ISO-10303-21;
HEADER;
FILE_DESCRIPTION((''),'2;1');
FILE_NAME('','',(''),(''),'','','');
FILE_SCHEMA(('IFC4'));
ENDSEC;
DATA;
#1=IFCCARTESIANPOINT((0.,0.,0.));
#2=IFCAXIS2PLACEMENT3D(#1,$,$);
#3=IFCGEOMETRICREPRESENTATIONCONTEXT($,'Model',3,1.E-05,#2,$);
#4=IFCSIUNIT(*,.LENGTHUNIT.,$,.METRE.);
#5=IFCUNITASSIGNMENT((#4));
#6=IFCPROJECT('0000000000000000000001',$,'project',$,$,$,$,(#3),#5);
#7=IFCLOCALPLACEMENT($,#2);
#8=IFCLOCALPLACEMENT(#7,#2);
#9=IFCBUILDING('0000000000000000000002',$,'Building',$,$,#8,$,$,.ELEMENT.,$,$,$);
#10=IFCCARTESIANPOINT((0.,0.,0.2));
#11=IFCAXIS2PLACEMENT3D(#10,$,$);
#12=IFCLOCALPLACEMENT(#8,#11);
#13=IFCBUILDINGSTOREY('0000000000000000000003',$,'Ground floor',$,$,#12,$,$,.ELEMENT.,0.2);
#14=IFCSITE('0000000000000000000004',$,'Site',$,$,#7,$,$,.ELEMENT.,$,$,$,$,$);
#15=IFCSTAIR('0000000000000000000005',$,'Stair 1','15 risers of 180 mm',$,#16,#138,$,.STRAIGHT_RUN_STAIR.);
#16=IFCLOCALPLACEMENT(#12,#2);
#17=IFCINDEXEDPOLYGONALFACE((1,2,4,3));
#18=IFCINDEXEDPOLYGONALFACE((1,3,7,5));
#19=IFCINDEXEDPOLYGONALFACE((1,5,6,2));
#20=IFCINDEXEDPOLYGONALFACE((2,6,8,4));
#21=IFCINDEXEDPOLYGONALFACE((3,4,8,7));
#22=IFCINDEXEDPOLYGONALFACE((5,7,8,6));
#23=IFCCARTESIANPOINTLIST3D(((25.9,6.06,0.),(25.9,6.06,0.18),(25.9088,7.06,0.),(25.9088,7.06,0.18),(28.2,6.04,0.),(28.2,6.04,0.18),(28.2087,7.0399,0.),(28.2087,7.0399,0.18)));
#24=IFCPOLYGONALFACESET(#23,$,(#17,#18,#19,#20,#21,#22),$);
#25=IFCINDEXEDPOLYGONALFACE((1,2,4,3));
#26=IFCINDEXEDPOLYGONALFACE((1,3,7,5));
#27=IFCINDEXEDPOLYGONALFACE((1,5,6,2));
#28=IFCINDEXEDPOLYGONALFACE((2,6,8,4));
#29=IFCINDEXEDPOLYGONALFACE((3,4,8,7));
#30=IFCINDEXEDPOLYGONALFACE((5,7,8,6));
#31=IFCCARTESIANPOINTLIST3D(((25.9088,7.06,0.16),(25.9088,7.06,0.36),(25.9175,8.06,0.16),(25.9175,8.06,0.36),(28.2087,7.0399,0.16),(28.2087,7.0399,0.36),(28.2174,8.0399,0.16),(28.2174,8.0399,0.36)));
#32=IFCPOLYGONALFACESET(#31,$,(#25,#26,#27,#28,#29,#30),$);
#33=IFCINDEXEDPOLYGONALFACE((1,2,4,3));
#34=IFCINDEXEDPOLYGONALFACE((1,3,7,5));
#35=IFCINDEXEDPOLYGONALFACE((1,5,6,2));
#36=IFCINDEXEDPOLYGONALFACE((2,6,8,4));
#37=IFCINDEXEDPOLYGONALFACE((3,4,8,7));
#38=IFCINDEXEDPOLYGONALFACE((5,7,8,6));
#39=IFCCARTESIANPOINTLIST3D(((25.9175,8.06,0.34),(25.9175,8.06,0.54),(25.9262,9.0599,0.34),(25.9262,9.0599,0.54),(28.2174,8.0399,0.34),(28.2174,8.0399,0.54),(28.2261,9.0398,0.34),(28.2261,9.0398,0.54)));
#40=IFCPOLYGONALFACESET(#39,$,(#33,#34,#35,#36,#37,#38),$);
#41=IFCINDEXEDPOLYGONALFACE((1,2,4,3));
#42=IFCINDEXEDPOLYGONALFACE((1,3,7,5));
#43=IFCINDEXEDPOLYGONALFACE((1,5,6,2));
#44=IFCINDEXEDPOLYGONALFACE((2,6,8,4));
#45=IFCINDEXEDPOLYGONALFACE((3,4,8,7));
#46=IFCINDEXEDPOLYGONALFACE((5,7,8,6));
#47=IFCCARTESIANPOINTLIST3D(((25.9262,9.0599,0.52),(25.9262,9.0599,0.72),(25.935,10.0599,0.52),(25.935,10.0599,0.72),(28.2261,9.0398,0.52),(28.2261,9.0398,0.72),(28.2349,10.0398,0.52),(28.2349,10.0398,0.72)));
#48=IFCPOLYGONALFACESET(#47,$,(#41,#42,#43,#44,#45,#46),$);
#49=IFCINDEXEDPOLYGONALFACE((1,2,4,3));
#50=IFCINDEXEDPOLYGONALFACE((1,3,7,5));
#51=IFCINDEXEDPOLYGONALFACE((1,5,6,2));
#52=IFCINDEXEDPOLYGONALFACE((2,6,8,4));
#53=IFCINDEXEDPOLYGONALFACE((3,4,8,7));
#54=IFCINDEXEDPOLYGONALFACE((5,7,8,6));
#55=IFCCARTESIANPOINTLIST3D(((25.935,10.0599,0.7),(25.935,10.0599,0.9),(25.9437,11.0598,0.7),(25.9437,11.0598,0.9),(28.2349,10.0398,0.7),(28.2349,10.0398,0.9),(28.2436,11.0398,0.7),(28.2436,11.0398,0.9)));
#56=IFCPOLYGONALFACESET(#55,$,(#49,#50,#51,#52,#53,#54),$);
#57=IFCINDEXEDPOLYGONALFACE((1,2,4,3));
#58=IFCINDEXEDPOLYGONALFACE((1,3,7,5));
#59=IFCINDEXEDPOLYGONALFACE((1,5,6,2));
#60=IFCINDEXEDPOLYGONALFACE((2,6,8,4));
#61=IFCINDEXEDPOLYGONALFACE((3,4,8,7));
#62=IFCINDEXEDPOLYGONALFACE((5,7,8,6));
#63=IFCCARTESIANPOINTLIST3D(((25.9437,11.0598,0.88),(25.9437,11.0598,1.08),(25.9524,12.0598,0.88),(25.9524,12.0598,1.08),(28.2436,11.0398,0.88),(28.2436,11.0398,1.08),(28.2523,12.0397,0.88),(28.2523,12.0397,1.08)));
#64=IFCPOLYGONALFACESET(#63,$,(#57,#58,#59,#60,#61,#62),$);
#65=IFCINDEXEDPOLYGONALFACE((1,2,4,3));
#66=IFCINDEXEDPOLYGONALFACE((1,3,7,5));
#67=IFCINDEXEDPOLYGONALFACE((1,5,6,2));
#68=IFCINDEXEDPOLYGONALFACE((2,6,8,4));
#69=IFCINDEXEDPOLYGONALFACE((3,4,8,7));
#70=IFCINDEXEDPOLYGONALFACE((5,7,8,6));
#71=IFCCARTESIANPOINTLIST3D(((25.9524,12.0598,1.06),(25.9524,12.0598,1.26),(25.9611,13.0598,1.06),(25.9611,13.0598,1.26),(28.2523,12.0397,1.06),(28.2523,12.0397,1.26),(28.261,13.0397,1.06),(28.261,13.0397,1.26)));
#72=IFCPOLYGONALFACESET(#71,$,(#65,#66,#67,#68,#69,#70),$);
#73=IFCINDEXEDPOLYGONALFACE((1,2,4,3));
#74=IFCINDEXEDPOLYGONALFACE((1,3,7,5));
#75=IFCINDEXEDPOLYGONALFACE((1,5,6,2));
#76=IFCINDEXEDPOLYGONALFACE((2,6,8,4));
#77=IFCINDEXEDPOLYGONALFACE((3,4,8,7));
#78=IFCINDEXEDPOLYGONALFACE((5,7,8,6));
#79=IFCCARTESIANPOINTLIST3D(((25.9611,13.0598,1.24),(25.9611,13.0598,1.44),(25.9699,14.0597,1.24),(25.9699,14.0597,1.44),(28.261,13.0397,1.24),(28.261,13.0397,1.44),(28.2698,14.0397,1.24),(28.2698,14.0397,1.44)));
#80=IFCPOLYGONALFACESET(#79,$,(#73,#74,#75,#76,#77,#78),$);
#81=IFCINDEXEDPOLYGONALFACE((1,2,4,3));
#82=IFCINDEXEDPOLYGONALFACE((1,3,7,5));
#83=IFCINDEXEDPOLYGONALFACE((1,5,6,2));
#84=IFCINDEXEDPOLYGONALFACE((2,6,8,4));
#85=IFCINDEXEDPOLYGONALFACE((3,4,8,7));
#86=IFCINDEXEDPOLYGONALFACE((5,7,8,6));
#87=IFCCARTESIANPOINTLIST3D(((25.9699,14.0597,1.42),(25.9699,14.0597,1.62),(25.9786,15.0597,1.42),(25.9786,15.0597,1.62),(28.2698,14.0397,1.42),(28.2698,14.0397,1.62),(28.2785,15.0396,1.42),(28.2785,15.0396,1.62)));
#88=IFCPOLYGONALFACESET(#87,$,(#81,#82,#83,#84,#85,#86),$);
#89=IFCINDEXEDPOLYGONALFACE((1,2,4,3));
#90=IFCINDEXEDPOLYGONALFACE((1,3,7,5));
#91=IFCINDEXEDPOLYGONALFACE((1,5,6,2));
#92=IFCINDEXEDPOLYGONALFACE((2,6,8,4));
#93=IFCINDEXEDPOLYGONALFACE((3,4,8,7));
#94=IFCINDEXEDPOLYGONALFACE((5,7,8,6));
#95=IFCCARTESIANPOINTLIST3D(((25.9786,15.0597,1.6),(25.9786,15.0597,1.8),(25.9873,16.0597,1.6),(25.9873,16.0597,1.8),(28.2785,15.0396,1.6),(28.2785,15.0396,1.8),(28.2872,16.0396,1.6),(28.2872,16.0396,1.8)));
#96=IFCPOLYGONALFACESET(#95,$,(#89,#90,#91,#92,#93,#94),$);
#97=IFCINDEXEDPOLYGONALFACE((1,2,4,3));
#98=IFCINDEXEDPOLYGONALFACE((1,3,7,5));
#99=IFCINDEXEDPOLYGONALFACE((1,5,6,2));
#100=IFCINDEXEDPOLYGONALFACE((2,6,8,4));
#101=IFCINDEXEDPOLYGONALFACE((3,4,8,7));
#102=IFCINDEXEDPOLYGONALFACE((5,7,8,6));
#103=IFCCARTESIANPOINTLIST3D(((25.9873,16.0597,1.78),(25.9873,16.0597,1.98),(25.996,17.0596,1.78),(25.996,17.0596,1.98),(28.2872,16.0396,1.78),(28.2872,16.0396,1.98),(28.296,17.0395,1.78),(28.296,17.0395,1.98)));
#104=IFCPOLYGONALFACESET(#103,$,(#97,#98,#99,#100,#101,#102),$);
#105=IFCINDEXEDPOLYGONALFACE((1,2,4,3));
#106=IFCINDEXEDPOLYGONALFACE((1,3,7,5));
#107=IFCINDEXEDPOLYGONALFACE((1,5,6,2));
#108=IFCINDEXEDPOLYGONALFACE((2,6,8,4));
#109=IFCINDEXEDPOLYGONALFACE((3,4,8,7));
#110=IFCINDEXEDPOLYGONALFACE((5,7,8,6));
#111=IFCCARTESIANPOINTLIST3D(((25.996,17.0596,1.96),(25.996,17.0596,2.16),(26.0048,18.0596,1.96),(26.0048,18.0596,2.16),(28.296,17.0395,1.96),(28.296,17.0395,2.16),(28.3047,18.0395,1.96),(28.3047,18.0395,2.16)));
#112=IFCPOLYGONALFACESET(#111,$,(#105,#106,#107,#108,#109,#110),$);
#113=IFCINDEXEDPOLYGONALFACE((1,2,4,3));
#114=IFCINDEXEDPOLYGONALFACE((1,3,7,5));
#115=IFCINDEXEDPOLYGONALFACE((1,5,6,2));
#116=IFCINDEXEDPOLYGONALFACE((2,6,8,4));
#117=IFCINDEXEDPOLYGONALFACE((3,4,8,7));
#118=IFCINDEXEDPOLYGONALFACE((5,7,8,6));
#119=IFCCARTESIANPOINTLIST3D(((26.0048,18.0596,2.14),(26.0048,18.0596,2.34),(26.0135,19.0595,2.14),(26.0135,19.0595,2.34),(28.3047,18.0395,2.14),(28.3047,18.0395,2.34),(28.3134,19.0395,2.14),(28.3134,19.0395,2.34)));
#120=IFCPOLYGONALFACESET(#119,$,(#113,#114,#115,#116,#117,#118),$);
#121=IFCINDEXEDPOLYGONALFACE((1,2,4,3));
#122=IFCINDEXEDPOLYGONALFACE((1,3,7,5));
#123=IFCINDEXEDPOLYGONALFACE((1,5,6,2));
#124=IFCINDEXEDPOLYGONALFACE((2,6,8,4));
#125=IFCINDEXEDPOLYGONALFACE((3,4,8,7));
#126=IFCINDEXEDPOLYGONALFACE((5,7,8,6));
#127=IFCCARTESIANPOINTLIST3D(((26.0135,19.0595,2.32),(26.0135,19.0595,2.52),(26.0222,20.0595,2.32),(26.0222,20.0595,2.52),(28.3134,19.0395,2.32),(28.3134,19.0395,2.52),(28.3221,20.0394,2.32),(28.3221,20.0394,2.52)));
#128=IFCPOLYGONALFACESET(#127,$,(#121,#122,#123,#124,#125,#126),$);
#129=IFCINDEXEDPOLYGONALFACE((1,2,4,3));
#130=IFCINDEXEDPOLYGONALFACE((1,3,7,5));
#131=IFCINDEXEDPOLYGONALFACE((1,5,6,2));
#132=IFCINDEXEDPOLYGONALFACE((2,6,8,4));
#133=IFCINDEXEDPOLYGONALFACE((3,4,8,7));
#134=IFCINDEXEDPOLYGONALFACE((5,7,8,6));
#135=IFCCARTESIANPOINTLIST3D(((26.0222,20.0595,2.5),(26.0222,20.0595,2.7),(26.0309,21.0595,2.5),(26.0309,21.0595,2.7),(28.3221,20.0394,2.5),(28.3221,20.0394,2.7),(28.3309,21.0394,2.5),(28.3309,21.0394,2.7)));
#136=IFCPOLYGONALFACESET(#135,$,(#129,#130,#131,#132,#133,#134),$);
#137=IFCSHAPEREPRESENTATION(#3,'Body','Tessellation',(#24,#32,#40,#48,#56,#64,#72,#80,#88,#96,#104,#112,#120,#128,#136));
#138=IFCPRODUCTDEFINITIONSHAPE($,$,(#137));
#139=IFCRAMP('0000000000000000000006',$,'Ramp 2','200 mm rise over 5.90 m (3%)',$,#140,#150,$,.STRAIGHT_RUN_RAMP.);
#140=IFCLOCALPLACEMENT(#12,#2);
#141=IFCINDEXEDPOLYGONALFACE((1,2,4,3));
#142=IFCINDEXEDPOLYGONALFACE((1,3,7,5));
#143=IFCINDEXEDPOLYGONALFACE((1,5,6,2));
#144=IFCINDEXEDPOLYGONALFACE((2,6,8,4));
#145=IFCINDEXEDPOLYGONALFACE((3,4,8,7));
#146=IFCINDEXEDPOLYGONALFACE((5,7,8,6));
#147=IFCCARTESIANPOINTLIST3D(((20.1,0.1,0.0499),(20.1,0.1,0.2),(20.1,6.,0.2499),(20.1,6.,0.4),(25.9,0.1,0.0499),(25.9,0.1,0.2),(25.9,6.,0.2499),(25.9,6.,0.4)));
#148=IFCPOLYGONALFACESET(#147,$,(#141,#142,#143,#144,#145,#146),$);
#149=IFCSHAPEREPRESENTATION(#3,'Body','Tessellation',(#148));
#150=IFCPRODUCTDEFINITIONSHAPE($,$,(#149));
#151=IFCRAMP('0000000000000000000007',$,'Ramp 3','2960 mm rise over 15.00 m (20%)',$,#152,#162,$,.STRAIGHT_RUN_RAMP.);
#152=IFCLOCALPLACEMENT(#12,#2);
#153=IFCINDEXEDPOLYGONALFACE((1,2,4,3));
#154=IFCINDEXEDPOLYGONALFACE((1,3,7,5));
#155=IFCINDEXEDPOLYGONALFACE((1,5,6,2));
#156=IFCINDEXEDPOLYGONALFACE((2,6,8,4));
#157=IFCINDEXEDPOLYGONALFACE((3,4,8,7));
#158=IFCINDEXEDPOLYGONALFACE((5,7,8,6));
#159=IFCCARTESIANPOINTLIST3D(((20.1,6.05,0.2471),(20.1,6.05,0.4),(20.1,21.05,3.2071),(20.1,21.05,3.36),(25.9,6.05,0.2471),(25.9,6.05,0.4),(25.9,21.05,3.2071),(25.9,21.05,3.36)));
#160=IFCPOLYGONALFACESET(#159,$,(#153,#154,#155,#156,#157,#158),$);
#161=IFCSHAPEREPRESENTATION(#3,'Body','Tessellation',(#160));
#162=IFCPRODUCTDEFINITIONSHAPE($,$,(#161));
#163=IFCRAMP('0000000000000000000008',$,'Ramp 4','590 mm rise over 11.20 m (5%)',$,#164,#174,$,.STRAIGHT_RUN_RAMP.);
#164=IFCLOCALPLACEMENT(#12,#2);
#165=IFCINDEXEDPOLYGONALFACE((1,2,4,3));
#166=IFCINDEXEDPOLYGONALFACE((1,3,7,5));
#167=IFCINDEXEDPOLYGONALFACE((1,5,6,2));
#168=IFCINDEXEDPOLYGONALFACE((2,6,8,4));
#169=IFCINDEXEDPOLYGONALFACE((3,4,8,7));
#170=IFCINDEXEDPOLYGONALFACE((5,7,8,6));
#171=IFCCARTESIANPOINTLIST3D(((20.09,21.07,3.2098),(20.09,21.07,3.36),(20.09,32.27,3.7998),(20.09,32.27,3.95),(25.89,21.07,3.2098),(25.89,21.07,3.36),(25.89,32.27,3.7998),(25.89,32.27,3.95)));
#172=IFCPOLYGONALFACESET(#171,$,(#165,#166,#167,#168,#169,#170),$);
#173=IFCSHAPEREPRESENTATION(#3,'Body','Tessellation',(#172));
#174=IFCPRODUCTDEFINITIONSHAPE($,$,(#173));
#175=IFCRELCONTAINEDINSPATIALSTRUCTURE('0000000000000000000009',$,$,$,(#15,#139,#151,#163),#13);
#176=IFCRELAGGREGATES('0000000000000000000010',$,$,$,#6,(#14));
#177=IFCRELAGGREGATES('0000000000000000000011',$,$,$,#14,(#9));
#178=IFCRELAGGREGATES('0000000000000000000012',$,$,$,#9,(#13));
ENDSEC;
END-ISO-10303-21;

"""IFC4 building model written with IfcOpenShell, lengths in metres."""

from ifc_helpers import new_model, si_unit, frame, origin, place, context, project, spatial, polyline, outline, extrude, element, save


model = new_model("IFC4")

# Units and contexts
model_context = context("Model", 3, precision=1e-05, world=origin())
ifc_project = project(units=[si_unit("LENGTHUNIT", "METRE")], contexts=[model_context])

# Site, building, storey
site_placement = place(None, origin())
site = spatial("IfcSite", under=ifc_project, at=site_placement, Name="Site", CompositionType="ELEMENT")
building_placement = place(site_placement, origin())
building = spatial("IfcBuilding", under=site, at=building_placement, Name="Building", CompositionType="ELEMENT")
storey_placement = place(building_placement, frame((0.0, 0.0, 0.2)))
storey = spatial("IfcBuildingStorey", under=building, at=storey_placement, Name="Ground floor", CompositionType="ELEMENT", Elevation=0.2)

# Stair
stair_placement = place(storey_placement, frame((27.05, 6.05, 0.0), z_axis=(0.0, 0.0, 1.0), x_axis=(0.008727, 0.999962, 0.0)))
element("IfcStair", 1, at=stair_placement, inside=storey, Name="Stair 1", Description="15 risers of 180 mm", PredefinedType="STRAIGHT_RUN_STAIR", context=model_context, shape_type="SweptSolid", body=[
    extrude(outline(polyline([(0.0, -1.15), (1.0, -1.15), (1.0, 1.15), (0.0, 1.15), (0.0, -1.15)])), origin(), (0.0, 0.0, 1.0), 0.18),
    extrude(outline(polyline([(1.0, -1.15), (2.0, -1.15), (2.0, 1.15), (1.0, 1.15), (1.0, -1.15)])), frame((0.0, 0.0, 0.16)), (0.0, 0.0, 1.0), 0.2),
    extrude(outline(polyline([(2.0, -1.15), (3.0, -1.15), (3.0, 1.15), (2.0, 1.15), (2.0, -1.15)])), frame((0.0, 0.0, 0.34)), (0.0, 0.0, 1.0), 0.2),
    extrude(outline(polyline([(3.0, -1.15), (4.0, -1.15), (4.0, 1.15), (3.0, 1.15), (3.0, -1.15)])), frame((0.0, 0.0, 0.52)), (0.0, 0.0, 1.0), 0.2),
    extrude(outline(polyline([(4.0, -1.15), (5.0, -1.15), (5.0, 1.15), (4.0, 1.15), (4.0, -1.15)])), frame((0.0, 0.0, 0.7)), (0.0, 0.0, 1.0), 0.2),
    extrude(outline(polyline([(5.0, -1.15), (6.0, -1.15), (6.0, 1.15), (5.0, 1.15), (5.0, -1.15)])), frame((0.0, 0.0, 0.88)), (0.0, 0.0, 1.0), 0.2),
    extrude(outline(polyline([(6.0, -1.15), (7.0, -1.15), (7.0, 1.15), (6.0, 1.15), (6.0, -1.15)])), frame((0.0, 0.0, 1.06)), (0.0, 0.0, 1.0), 0.2),
    extrude(outline(polyline([(7.0, -1.15), (8.0, -1.15), (8.0, 1.15), (7.0, 1.15), (7.0, -1.15)])), frame((0.0, 0.0, 1.24)), (0.0, 0.0, 1.0), 0.2),
    extrude(outline(polyline([(8.0, -1.15), (9.0, -1.15), (9.0, 1.15), (8.0, 1.15), (8.0, -1.15)])), frame((0.0, 0.0, 1.42)), (0.0, 0.0, 1.0), 0.2),
    extrude(outline(polyline([(9.0, -1.15), (10.0, -1.15), (10.0, 1.15), (9.0, 1.15), (9.0, -1.15)])), frame((0.0, 0.0, 1.6)), (0.0, 0.0, 1.0), 0.2),
    extrude(outline(polyline([(10.0, -1.15), (11.0, -1.15), (11.0, 1.15), (10.0, 1.15), (10.0, -1.15)])), frame((0.0, 0.0, 1.78)), (0.0, 0.0, 1.0), 0.2),
    extrude(outline(polyline([(11.0, -1.15), (12.0, -1.15), (12.0, 1.15), (11.0, 1.15), (11.0, -1.15)])), frame((0.0, 0.0, 1.96)), (0.0, 0.0, 1.0), 0.2),
    extrude(outline(polyline([(12.0, -1.15), (13.0, -1.15), (13.0, 1.15), (12.0, 1.15), (12.0, -1.15)])), frame((0.0, 0.0, 2.14)), (0.0, 0.0, 1.0), 0.2),
    extrude(outline(polyline([(13.0, -1.15), (14.0, -1.15), (14.0, 1.15), (13.0, 1.15), (13.0, -1.15)])), frame((0.0, 0.0, 2.32)), (0.0, 0.0, 1.0), 0.2),
    extrude(outline(polyline([(14.0, -1.15), (15.0, -1.15), (15.0, 1.15), (14.0, 1.15), (14.0, -1.15)])), frame((0.0, 0.0, 2.5)), (0.0, 0.0, 1.0), 0.2),
])

# Ramps
ramp_1_placement = place(storey_placement, frame((23.0, 0.1, 0.2), z_axis=(0.0, 0.0, 1.0), x_axis=(0.0, 1.0, 0.0)))
element("IfcRamp", 2, at=ramp_1_placement, inside=storey, Name="Ramp 2", Description="200 mm rise over 5.90 m (3%)", PredefinedType="STRAIGHT_RUN_RAMP", context=model_context, shape_type="SweptSolid", body=[
    extrude(outline(polyline([(0.0, -0.1501), (5.9, 0.0499), (5.9, 0.2), (0.0, 0.0), (0.0, -0.1501)])), frame((0.0, 2.9, 0.0), z_axis=(0.0, -1.0, 0.0), x_axis=(1.0, 0.0, 0.0)), (0.0, 0.0, 1.0), 5.8),
])
ramp_2_placement = place(storey_placement, frame((23.0, 6.05, 0.4), z_axis=(0.0, 0.0, 1.0), x_axis=(0.0, 1.0, 0.0)))
element("IfcRamp", 3, at=ramp_2_placement, inside=storey, Name="Ramp 3", Description="2960 mm rise over 15.00 m (20%)", PredefinedType="STRAIGHT_RUN_RAMP", context=model_context, shape_type="SweptSolid", body=[
    extrude(outline(polyline([(0.0, -0.1529), (15.0, 2.8071), (15.0, 2.96), (0.0, 0.0), (0.0, -0.1529)])), frame((0.0, 2.9, 0.0), z_axis=(0.0, -1.0, 0.0), x_axis=(1.0, 0.0, 0.0)), (0.0, 0.0, 1.0), 5.8),
])
ramp_3_placement = place(storey_placement, frame((22.99, 21.07, 3.36), z_axis=(0.0, 0.0, 1.0), x_axis=(0.0, 1.0, 0.0)))
element("IfcRamp", 4, at=ramp_3_placement, inside=storey, Name="Ramp 4", Description="590 mm rise over 11.20 m (5%)", PredefinedType="STRAIGHT_RUN_RAMP", context=model_context, shape_type="SweptSolid", body=[
    extrude(outline(polyline([(0.0, -0.1502), (11.2, 0.4398), (11.2, 0.59), (0.0, 0.0), (0.0, -0.1502)])), frame((0.0, 2.9, 0.0), z_axis=(0.0, -1.0, 0.0), x_axis=(1.0, 0.0, 0.0)), (0.0, 0.0, 1.0), 5.8),
])

save(model, "model.ifc")
